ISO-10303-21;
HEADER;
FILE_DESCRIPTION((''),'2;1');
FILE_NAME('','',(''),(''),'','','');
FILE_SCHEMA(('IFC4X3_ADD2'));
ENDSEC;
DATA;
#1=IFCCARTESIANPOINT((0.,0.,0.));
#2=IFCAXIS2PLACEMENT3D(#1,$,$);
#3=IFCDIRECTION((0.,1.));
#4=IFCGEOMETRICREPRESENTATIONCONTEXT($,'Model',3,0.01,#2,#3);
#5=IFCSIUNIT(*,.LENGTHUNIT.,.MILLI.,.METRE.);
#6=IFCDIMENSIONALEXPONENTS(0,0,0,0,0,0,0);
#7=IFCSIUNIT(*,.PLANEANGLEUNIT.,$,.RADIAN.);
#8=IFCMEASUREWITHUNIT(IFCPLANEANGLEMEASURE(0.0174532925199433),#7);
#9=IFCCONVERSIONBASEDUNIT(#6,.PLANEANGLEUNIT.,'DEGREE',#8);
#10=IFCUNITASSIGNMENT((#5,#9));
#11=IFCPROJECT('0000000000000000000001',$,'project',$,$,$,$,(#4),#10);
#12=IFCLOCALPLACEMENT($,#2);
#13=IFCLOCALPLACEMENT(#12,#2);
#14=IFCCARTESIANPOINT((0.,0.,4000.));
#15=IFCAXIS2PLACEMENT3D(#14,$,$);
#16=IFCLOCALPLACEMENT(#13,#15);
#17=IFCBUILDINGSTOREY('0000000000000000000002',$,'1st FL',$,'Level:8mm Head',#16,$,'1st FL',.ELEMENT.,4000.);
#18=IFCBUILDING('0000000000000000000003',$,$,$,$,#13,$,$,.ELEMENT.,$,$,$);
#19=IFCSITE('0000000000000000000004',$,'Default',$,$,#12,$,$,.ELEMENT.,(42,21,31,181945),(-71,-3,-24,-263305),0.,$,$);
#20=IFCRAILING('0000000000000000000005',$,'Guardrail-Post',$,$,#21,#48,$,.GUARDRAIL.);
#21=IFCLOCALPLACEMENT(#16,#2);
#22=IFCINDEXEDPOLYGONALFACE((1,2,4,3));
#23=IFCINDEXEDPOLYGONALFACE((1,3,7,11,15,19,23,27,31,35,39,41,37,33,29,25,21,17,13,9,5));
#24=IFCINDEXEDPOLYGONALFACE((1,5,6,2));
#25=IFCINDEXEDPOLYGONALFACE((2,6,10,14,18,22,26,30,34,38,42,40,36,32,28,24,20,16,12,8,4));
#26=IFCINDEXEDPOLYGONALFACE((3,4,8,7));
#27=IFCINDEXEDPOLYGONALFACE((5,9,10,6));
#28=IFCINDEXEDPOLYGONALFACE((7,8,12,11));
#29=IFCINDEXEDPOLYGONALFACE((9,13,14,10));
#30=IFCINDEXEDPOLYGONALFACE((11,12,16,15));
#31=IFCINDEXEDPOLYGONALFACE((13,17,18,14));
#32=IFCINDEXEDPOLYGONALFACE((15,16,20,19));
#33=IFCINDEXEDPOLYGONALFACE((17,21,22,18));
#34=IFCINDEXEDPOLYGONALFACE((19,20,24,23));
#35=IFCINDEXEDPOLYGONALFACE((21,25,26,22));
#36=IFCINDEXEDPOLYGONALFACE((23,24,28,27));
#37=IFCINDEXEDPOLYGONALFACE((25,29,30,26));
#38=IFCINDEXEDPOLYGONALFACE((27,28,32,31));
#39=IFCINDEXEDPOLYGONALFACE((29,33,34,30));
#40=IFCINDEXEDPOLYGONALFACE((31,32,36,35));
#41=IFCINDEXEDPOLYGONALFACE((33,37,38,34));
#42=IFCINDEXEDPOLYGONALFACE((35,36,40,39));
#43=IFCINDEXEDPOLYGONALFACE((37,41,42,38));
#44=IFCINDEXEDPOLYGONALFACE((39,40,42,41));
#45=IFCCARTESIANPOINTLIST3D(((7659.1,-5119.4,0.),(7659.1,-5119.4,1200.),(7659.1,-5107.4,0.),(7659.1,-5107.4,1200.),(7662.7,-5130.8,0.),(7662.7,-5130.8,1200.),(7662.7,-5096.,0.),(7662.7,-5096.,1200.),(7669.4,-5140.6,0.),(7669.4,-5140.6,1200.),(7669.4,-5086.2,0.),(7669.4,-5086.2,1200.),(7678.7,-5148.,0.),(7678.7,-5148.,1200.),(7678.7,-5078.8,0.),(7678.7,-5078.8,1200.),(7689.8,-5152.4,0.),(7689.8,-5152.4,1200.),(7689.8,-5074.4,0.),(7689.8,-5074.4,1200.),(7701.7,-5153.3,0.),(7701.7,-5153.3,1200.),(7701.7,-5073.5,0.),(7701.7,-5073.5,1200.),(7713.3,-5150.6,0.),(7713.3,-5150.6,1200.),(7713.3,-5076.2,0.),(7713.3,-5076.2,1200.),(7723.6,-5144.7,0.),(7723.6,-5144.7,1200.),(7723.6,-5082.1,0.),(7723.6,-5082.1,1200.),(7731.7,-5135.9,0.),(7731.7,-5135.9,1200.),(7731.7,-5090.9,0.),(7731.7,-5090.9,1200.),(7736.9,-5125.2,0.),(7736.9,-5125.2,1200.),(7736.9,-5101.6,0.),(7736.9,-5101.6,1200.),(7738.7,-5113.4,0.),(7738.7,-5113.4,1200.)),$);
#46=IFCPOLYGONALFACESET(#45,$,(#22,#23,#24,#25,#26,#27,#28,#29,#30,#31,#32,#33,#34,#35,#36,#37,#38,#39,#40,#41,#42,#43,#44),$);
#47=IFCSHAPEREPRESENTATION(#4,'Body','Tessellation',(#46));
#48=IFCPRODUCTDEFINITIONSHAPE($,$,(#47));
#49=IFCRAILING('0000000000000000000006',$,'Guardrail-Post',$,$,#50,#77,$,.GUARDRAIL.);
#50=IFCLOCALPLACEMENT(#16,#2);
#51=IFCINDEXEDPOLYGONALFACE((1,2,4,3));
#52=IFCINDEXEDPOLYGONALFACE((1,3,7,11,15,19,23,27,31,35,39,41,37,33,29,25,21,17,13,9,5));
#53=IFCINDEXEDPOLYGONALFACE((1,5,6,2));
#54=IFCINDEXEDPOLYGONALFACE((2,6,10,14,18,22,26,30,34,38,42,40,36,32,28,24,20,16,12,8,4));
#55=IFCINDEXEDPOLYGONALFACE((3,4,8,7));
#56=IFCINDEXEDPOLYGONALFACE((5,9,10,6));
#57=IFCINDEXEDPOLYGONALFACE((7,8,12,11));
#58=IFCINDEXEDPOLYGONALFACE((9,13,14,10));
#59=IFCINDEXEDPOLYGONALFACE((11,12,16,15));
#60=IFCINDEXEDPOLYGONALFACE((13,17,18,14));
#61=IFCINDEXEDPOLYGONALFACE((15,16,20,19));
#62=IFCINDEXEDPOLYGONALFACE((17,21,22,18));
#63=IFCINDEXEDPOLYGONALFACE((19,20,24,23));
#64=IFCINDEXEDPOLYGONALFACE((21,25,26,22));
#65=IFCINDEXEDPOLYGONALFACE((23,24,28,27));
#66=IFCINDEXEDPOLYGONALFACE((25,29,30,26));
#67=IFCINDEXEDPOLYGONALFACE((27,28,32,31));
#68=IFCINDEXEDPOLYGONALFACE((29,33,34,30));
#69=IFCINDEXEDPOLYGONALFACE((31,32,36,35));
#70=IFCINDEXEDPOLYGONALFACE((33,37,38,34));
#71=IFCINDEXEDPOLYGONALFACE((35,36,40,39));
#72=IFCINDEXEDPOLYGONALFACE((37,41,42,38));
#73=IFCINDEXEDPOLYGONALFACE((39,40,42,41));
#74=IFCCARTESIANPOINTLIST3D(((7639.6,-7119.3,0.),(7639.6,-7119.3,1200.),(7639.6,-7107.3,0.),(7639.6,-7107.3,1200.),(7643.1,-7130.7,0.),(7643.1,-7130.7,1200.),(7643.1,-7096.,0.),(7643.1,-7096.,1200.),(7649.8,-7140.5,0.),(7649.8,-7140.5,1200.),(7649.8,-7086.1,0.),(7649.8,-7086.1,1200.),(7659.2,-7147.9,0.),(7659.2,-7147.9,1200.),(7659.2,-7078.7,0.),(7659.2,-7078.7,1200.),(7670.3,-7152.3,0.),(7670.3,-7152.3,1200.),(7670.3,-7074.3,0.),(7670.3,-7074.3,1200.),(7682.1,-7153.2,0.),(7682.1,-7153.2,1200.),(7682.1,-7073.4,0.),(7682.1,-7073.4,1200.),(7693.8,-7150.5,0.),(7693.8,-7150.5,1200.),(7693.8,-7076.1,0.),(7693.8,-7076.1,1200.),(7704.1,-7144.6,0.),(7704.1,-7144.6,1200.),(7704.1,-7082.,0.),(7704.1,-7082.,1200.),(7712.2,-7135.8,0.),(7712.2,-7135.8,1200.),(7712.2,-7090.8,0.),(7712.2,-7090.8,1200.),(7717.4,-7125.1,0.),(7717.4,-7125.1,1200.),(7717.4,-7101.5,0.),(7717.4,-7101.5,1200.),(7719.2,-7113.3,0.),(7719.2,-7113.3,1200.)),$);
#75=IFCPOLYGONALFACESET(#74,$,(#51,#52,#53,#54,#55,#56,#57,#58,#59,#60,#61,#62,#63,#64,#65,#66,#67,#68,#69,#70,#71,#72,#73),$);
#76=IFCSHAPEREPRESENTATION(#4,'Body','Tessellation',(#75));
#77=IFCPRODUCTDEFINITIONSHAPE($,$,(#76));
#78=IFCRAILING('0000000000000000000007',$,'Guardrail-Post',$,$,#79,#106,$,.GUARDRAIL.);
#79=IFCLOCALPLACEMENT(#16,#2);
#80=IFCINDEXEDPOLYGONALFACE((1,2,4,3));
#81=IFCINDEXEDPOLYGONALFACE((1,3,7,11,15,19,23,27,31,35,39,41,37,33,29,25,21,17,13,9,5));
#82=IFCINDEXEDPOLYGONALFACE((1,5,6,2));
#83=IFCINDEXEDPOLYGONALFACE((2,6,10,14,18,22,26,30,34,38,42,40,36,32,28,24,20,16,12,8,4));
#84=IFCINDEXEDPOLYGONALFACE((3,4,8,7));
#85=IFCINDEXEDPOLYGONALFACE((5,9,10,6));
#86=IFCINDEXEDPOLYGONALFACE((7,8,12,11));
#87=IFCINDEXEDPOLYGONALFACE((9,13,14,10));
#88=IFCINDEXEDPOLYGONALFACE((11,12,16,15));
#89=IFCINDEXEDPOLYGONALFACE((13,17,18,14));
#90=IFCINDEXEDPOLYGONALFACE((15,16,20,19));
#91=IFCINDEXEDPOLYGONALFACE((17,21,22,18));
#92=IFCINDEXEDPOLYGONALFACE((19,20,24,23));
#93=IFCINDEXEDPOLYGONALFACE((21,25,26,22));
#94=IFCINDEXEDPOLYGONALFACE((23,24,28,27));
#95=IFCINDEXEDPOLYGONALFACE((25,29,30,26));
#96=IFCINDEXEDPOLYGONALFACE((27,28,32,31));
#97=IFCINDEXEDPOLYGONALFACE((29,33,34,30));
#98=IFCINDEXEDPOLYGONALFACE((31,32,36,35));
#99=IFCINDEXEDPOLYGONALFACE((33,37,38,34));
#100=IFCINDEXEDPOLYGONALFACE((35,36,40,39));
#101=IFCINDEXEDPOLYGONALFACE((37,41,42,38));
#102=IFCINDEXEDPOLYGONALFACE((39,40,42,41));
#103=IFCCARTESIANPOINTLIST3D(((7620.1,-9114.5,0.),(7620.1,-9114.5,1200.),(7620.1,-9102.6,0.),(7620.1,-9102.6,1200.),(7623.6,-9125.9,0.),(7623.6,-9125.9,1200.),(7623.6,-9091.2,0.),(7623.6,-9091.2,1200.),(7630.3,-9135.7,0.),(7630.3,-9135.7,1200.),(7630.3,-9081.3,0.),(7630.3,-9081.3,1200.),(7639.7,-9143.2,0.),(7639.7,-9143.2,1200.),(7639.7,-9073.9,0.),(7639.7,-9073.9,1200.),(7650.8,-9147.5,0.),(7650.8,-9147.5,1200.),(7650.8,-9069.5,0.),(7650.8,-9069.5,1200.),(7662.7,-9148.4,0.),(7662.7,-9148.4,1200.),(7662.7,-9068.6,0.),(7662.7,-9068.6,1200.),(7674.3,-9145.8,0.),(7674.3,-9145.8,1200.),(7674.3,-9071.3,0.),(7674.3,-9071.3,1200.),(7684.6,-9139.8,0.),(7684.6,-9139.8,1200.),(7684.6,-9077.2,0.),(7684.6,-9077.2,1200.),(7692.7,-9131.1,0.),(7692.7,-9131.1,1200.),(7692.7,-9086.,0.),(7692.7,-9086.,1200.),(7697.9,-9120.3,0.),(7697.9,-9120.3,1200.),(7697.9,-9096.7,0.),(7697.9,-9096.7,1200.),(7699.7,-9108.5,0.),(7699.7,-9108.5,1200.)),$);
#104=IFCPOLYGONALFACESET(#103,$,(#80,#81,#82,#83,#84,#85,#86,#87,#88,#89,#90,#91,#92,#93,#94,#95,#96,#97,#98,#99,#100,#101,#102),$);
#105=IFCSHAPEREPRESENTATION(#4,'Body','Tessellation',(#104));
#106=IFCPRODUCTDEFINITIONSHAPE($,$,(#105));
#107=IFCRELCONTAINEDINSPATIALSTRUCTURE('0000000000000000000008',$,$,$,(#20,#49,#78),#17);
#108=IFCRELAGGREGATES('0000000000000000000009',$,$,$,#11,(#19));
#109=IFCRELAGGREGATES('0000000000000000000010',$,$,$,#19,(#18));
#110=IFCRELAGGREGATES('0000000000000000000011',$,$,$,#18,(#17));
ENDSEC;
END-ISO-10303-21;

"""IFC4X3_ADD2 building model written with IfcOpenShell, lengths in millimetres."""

from ifc_helpers import new_model, entity, si_unit, converted_unit, direction, frame, origin, origin_with_axes, origin_2d, place, context, project, spatial, circle, extrude, element, save


model = new_model("IFC4X3_ADD2")

# Units and contexts
model_context = context("Model", 3, precision=0.01, world=origin(), true_north=direction((0.0, 1.0)))
ifc_project = project(units=[si_unit("LENGTHUNIT", "METRE", prefix="MILLI"), converted_unit("PLANEANGLEUNIT", "DEGREE", entity("IfcPlaneAngleMeasure", 0.0174532925199433), si_unit("PLANEANGLEUNIT", "RADIAN"), dimensions=[0, 0, 0, 0, 0, 0, 0])], contexts=[model_context])

# Site, building, storey
site_placement = place(None, origin())
site = spatial("IfcSite", under=ifc_project, at=site_placement, Name="Default", CompositionType="ELEMENT", RefLatitude=(42, 21, 31, 181945), RefLongitude=(-71, -3, -24, -263305), RefElevation=0.0)
building_placement = place(site_placement, origin())
building = spatial("IfcBuilding", under=site, at=building_placement, CompositionType="ELEMENT")
storey_placement = place(building_placement, frame((0.0, 0.0, 4000.0)))
storey = spatial("IfcBuildingStorey", under=building, at=storey_placement, Name="1st FL", ObjectType="Level:8mm Head", LongName="1st FL", CompositionType="ELEMENT", Elevation=4000.0)

# Railings
for number, where, z_axis, x_axis, name in (
    (1, (7698.7, -5113.4, 4000.0), (0.0, 0.0, 1.0), (1.0, 0.0, 0.0), "Guardrail-Post"),
    (2, (7679.2, -7113.3, 4000.0), (0.0, 0.0, 1.0), (1.0, 0.0, 0.0), "Guardrail-Post"),
    (3, (7659.7, -9108.5, 4000.0), (0.0, 0.0, 1.0), (1.0, 0.0, 0.0), "Guardrail-Post"),
):
    element("IfcRailing", number, at=place(None, frame(where, z_axis=z_axis, x_axis=x_axis)), inside=storey, Name=name, PredefinedType="GUARDRAIL", context=model_context, shape_type="SweptSolid", body=[
        extrude(circle(Radius=40.0, at=origin_2d()), origin_with_axes(), (0.0, 0.0, 1.0), 1200.0),
    ])

save(model, "model.ifc")
